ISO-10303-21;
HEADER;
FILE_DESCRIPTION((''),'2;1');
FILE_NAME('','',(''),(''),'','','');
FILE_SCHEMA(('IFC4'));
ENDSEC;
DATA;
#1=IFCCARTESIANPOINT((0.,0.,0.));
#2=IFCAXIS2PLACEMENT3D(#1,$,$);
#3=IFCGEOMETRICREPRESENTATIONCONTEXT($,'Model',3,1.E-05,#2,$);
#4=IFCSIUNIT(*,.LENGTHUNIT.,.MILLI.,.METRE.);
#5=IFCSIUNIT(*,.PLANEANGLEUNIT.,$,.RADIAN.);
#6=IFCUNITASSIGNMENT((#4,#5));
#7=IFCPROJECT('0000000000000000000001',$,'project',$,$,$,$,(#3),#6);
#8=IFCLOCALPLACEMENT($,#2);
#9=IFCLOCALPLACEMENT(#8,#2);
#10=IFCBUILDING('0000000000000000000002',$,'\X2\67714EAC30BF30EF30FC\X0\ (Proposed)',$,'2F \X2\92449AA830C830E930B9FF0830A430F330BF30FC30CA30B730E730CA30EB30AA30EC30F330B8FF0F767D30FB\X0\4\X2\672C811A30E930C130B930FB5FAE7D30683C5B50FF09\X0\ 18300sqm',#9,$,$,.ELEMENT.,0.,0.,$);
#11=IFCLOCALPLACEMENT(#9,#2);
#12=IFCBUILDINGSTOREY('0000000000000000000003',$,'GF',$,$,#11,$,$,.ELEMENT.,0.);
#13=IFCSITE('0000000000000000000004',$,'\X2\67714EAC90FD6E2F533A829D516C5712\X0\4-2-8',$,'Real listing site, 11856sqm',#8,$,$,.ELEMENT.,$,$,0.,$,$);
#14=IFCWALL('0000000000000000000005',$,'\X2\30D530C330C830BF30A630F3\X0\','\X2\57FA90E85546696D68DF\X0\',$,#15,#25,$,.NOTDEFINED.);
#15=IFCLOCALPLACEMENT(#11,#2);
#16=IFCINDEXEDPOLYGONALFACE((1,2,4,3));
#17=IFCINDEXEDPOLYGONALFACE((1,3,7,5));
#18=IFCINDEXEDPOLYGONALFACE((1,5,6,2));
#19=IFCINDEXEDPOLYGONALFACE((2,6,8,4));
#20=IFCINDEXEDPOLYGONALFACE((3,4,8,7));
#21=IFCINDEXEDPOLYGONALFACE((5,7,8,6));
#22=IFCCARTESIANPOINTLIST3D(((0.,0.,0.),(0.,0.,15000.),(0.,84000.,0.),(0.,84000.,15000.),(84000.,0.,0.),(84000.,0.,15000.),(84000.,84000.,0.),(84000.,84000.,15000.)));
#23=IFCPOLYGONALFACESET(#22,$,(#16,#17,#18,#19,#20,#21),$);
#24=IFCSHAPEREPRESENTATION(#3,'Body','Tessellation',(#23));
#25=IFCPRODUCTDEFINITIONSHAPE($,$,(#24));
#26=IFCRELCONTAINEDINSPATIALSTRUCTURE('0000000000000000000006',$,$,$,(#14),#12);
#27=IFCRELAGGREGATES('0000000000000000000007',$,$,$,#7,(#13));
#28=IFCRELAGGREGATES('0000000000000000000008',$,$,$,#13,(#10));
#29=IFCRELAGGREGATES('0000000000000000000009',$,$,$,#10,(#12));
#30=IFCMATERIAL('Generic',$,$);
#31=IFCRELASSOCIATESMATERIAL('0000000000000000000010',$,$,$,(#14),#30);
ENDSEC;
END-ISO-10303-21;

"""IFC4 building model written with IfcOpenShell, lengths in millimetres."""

from ifc_helpers import new_model, si_unit, frame_2d, origin, place, context, project, spatial, rectangle, extrude, material, element, save


model = new_model("IFC4")

# Units and contexts
model_context = context("Model", 3, precision=1e-05, world=origin())
ifc_project = project(units=[si_unit("LENGTHUNIT", "METRE", prefix="MILLI"), si_unit("PLANEANGLEUNIT", "RADIAN")], contexts=[model_context])

# Site, building, storey
site_placement = place(None, origin())
site = spatial("IfcSite", under=ifc_project, at=site_placement, Name="東京都港区芝公園4-2-8", ObjectType="Real listing site, 11856sqm", CompositionType="ELEMENT", RefElevation=0.0)
building_placement = place(site_placement, origin())
building = spatial("IfcBuilding", under=site, at=building_placement, Name="東京タワー (Proposed)", ObjectType="2F 鉄骨トラス（インターナショナルオレンジ／白・4本脚ラチス・微細格子） 18300sqm", CompositionType="ELEMENT", ElevationOfRefHeight=0.0, ElevationOfTerrain=0.0)
storey_placement = place(building_placement, origin())
storey = spatial("IfcBuildingStorey", under=building, at=storey_placement, Name="GF", CompositionType="ELEMENT", Elevation=0.0)

# Shared definitions
ifc_material = material(Name="Generic")

# Wall
wall_placement = place(storey_placement, origin())
element("IfcWall", 1, at=wall_placement, inside=storey, material=ifc_material, Name="フットタウン", Description="基部商業棟", PredefinedType="NOTDEFINED", context=model_context, shape_type="SweptSolid", body=[
    extrude(rectangle(XDim=84000.0, YDim=84000.0, at=frame_2d((42000.0, 42000.0))), origin(), (0.0, 0.0, 1.0), 15000.0),
])

save(model, "model.ifc")
